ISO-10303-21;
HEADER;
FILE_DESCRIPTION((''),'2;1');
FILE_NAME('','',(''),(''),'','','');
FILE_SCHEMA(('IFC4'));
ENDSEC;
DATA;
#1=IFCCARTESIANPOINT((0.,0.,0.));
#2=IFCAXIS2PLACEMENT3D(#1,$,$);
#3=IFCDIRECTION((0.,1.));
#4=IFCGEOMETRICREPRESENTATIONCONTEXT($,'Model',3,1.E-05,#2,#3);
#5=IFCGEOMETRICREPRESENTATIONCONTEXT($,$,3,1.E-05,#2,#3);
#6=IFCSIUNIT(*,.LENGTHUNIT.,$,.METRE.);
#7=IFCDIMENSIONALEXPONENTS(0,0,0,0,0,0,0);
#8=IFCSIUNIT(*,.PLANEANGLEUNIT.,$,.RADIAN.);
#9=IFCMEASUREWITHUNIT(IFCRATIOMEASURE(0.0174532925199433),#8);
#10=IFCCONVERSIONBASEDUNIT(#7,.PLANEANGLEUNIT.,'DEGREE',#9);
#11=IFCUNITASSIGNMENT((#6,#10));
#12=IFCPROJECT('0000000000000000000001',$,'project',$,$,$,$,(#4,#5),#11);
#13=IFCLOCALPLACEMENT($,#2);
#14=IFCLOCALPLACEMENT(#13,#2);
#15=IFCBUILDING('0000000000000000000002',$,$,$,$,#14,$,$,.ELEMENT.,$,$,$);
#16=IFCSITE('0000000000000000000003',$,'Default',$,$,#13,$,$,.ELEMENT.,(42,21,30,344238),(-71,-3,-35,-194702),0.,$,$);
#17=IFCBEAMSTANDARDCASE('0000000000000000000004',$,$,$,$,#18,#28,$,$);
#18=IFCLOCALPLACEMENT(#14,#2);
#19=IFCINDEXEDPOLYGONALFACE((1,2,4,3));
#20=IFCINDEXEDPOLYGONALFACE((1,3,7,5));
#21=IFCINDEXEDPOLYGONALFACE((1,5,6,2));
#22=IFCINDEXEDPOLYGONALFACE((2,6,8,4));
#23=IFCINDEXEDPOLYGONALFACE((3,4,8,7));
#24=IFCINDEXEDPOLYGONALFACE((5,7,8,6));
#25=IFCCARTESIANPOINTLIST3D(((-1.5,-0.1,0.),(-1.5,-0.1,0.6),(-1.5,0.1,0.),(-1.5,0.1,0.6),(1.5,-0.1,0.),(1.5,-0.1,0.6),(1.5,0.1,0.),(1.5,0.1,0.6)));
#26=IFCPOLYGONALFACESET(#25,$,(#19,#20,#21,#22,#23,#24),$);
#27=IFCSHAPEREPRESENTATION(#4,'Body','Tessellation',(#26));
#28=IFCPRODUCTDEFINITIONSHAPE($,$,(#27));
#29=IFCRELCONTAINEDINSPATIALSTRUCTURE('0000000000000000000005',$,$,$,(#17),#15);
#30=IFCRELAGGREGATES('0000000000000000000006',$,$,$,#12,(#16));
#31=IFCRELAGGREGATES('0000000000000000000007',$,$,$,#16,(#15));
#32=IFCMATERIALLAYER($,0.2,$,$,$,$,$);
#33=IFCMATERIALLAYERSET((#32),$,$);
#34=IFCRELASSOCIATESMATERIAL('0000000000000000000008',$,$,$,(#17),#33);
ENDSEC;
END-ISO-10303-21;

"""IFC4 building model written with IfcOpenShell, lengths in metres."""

from ifc_helpers import new_model, entity, si_unit, converted_unit, direction, origin, place, context, project, spatial, rectangle, extrude, layer, layer_set, layer_usage, element, save


model = new_model("IFC4")

# Units and contexts
model_context = context("Model", 3, precision=1e-05, world=origin(), true_north=direction((0.0, 1.0)))
context_of_model = context(None, 3, precision=1e-05, world=origin(), true_north=direction((0.0, 1.0)))
ifc_project = project(units=[si_unit("LENGTHUNIT", "METRE"), converted_unit("PLANEANGLEUNIT", "DEGREE", entity("IfcRatioMeasure", 0.0174532925199433), si_unit("PLANEANGLEUNIT", "RADIAN"), dimensions=[0, 0, 0, 0, 0, 0, 0])], contexts=[model_context, context_of_model])

# Site, building
site_placement = place(None, origin())
site = spatial("IfcSite", under=ifc_project, at=site_placement, Name="Default", CompositionType="ELEMENT", RefLatitude=(42, 21, 30, 344238), RefLongitude=(-71, -3, -35, -194702), RefElevation=0.0)
building_placement = place(site_placement, origin())
building = spatial("IfcBuilding", under=site, at=building_placement, CompositionType="ELEMENT")

# Beam
ifc_layer = layer(None, 0.2)
ifc_layer_set = layer_set([ifc_layer])
ifc_layer_usage = layer_usage(ifc_layer_set, "AXIS2", "POSITIVE", 10.0)
element("IfcBeamStandardCase", 1, inside=building, material=ifc_layer_usage, context=model_context, shape_type="SweptSolid", body=[
    extrude(rectangle(XDim=3.0, YDim=0.2), origin(), (0.0, 0.0, 1.0), 0.6),
])

save(model, "model.ifc")
